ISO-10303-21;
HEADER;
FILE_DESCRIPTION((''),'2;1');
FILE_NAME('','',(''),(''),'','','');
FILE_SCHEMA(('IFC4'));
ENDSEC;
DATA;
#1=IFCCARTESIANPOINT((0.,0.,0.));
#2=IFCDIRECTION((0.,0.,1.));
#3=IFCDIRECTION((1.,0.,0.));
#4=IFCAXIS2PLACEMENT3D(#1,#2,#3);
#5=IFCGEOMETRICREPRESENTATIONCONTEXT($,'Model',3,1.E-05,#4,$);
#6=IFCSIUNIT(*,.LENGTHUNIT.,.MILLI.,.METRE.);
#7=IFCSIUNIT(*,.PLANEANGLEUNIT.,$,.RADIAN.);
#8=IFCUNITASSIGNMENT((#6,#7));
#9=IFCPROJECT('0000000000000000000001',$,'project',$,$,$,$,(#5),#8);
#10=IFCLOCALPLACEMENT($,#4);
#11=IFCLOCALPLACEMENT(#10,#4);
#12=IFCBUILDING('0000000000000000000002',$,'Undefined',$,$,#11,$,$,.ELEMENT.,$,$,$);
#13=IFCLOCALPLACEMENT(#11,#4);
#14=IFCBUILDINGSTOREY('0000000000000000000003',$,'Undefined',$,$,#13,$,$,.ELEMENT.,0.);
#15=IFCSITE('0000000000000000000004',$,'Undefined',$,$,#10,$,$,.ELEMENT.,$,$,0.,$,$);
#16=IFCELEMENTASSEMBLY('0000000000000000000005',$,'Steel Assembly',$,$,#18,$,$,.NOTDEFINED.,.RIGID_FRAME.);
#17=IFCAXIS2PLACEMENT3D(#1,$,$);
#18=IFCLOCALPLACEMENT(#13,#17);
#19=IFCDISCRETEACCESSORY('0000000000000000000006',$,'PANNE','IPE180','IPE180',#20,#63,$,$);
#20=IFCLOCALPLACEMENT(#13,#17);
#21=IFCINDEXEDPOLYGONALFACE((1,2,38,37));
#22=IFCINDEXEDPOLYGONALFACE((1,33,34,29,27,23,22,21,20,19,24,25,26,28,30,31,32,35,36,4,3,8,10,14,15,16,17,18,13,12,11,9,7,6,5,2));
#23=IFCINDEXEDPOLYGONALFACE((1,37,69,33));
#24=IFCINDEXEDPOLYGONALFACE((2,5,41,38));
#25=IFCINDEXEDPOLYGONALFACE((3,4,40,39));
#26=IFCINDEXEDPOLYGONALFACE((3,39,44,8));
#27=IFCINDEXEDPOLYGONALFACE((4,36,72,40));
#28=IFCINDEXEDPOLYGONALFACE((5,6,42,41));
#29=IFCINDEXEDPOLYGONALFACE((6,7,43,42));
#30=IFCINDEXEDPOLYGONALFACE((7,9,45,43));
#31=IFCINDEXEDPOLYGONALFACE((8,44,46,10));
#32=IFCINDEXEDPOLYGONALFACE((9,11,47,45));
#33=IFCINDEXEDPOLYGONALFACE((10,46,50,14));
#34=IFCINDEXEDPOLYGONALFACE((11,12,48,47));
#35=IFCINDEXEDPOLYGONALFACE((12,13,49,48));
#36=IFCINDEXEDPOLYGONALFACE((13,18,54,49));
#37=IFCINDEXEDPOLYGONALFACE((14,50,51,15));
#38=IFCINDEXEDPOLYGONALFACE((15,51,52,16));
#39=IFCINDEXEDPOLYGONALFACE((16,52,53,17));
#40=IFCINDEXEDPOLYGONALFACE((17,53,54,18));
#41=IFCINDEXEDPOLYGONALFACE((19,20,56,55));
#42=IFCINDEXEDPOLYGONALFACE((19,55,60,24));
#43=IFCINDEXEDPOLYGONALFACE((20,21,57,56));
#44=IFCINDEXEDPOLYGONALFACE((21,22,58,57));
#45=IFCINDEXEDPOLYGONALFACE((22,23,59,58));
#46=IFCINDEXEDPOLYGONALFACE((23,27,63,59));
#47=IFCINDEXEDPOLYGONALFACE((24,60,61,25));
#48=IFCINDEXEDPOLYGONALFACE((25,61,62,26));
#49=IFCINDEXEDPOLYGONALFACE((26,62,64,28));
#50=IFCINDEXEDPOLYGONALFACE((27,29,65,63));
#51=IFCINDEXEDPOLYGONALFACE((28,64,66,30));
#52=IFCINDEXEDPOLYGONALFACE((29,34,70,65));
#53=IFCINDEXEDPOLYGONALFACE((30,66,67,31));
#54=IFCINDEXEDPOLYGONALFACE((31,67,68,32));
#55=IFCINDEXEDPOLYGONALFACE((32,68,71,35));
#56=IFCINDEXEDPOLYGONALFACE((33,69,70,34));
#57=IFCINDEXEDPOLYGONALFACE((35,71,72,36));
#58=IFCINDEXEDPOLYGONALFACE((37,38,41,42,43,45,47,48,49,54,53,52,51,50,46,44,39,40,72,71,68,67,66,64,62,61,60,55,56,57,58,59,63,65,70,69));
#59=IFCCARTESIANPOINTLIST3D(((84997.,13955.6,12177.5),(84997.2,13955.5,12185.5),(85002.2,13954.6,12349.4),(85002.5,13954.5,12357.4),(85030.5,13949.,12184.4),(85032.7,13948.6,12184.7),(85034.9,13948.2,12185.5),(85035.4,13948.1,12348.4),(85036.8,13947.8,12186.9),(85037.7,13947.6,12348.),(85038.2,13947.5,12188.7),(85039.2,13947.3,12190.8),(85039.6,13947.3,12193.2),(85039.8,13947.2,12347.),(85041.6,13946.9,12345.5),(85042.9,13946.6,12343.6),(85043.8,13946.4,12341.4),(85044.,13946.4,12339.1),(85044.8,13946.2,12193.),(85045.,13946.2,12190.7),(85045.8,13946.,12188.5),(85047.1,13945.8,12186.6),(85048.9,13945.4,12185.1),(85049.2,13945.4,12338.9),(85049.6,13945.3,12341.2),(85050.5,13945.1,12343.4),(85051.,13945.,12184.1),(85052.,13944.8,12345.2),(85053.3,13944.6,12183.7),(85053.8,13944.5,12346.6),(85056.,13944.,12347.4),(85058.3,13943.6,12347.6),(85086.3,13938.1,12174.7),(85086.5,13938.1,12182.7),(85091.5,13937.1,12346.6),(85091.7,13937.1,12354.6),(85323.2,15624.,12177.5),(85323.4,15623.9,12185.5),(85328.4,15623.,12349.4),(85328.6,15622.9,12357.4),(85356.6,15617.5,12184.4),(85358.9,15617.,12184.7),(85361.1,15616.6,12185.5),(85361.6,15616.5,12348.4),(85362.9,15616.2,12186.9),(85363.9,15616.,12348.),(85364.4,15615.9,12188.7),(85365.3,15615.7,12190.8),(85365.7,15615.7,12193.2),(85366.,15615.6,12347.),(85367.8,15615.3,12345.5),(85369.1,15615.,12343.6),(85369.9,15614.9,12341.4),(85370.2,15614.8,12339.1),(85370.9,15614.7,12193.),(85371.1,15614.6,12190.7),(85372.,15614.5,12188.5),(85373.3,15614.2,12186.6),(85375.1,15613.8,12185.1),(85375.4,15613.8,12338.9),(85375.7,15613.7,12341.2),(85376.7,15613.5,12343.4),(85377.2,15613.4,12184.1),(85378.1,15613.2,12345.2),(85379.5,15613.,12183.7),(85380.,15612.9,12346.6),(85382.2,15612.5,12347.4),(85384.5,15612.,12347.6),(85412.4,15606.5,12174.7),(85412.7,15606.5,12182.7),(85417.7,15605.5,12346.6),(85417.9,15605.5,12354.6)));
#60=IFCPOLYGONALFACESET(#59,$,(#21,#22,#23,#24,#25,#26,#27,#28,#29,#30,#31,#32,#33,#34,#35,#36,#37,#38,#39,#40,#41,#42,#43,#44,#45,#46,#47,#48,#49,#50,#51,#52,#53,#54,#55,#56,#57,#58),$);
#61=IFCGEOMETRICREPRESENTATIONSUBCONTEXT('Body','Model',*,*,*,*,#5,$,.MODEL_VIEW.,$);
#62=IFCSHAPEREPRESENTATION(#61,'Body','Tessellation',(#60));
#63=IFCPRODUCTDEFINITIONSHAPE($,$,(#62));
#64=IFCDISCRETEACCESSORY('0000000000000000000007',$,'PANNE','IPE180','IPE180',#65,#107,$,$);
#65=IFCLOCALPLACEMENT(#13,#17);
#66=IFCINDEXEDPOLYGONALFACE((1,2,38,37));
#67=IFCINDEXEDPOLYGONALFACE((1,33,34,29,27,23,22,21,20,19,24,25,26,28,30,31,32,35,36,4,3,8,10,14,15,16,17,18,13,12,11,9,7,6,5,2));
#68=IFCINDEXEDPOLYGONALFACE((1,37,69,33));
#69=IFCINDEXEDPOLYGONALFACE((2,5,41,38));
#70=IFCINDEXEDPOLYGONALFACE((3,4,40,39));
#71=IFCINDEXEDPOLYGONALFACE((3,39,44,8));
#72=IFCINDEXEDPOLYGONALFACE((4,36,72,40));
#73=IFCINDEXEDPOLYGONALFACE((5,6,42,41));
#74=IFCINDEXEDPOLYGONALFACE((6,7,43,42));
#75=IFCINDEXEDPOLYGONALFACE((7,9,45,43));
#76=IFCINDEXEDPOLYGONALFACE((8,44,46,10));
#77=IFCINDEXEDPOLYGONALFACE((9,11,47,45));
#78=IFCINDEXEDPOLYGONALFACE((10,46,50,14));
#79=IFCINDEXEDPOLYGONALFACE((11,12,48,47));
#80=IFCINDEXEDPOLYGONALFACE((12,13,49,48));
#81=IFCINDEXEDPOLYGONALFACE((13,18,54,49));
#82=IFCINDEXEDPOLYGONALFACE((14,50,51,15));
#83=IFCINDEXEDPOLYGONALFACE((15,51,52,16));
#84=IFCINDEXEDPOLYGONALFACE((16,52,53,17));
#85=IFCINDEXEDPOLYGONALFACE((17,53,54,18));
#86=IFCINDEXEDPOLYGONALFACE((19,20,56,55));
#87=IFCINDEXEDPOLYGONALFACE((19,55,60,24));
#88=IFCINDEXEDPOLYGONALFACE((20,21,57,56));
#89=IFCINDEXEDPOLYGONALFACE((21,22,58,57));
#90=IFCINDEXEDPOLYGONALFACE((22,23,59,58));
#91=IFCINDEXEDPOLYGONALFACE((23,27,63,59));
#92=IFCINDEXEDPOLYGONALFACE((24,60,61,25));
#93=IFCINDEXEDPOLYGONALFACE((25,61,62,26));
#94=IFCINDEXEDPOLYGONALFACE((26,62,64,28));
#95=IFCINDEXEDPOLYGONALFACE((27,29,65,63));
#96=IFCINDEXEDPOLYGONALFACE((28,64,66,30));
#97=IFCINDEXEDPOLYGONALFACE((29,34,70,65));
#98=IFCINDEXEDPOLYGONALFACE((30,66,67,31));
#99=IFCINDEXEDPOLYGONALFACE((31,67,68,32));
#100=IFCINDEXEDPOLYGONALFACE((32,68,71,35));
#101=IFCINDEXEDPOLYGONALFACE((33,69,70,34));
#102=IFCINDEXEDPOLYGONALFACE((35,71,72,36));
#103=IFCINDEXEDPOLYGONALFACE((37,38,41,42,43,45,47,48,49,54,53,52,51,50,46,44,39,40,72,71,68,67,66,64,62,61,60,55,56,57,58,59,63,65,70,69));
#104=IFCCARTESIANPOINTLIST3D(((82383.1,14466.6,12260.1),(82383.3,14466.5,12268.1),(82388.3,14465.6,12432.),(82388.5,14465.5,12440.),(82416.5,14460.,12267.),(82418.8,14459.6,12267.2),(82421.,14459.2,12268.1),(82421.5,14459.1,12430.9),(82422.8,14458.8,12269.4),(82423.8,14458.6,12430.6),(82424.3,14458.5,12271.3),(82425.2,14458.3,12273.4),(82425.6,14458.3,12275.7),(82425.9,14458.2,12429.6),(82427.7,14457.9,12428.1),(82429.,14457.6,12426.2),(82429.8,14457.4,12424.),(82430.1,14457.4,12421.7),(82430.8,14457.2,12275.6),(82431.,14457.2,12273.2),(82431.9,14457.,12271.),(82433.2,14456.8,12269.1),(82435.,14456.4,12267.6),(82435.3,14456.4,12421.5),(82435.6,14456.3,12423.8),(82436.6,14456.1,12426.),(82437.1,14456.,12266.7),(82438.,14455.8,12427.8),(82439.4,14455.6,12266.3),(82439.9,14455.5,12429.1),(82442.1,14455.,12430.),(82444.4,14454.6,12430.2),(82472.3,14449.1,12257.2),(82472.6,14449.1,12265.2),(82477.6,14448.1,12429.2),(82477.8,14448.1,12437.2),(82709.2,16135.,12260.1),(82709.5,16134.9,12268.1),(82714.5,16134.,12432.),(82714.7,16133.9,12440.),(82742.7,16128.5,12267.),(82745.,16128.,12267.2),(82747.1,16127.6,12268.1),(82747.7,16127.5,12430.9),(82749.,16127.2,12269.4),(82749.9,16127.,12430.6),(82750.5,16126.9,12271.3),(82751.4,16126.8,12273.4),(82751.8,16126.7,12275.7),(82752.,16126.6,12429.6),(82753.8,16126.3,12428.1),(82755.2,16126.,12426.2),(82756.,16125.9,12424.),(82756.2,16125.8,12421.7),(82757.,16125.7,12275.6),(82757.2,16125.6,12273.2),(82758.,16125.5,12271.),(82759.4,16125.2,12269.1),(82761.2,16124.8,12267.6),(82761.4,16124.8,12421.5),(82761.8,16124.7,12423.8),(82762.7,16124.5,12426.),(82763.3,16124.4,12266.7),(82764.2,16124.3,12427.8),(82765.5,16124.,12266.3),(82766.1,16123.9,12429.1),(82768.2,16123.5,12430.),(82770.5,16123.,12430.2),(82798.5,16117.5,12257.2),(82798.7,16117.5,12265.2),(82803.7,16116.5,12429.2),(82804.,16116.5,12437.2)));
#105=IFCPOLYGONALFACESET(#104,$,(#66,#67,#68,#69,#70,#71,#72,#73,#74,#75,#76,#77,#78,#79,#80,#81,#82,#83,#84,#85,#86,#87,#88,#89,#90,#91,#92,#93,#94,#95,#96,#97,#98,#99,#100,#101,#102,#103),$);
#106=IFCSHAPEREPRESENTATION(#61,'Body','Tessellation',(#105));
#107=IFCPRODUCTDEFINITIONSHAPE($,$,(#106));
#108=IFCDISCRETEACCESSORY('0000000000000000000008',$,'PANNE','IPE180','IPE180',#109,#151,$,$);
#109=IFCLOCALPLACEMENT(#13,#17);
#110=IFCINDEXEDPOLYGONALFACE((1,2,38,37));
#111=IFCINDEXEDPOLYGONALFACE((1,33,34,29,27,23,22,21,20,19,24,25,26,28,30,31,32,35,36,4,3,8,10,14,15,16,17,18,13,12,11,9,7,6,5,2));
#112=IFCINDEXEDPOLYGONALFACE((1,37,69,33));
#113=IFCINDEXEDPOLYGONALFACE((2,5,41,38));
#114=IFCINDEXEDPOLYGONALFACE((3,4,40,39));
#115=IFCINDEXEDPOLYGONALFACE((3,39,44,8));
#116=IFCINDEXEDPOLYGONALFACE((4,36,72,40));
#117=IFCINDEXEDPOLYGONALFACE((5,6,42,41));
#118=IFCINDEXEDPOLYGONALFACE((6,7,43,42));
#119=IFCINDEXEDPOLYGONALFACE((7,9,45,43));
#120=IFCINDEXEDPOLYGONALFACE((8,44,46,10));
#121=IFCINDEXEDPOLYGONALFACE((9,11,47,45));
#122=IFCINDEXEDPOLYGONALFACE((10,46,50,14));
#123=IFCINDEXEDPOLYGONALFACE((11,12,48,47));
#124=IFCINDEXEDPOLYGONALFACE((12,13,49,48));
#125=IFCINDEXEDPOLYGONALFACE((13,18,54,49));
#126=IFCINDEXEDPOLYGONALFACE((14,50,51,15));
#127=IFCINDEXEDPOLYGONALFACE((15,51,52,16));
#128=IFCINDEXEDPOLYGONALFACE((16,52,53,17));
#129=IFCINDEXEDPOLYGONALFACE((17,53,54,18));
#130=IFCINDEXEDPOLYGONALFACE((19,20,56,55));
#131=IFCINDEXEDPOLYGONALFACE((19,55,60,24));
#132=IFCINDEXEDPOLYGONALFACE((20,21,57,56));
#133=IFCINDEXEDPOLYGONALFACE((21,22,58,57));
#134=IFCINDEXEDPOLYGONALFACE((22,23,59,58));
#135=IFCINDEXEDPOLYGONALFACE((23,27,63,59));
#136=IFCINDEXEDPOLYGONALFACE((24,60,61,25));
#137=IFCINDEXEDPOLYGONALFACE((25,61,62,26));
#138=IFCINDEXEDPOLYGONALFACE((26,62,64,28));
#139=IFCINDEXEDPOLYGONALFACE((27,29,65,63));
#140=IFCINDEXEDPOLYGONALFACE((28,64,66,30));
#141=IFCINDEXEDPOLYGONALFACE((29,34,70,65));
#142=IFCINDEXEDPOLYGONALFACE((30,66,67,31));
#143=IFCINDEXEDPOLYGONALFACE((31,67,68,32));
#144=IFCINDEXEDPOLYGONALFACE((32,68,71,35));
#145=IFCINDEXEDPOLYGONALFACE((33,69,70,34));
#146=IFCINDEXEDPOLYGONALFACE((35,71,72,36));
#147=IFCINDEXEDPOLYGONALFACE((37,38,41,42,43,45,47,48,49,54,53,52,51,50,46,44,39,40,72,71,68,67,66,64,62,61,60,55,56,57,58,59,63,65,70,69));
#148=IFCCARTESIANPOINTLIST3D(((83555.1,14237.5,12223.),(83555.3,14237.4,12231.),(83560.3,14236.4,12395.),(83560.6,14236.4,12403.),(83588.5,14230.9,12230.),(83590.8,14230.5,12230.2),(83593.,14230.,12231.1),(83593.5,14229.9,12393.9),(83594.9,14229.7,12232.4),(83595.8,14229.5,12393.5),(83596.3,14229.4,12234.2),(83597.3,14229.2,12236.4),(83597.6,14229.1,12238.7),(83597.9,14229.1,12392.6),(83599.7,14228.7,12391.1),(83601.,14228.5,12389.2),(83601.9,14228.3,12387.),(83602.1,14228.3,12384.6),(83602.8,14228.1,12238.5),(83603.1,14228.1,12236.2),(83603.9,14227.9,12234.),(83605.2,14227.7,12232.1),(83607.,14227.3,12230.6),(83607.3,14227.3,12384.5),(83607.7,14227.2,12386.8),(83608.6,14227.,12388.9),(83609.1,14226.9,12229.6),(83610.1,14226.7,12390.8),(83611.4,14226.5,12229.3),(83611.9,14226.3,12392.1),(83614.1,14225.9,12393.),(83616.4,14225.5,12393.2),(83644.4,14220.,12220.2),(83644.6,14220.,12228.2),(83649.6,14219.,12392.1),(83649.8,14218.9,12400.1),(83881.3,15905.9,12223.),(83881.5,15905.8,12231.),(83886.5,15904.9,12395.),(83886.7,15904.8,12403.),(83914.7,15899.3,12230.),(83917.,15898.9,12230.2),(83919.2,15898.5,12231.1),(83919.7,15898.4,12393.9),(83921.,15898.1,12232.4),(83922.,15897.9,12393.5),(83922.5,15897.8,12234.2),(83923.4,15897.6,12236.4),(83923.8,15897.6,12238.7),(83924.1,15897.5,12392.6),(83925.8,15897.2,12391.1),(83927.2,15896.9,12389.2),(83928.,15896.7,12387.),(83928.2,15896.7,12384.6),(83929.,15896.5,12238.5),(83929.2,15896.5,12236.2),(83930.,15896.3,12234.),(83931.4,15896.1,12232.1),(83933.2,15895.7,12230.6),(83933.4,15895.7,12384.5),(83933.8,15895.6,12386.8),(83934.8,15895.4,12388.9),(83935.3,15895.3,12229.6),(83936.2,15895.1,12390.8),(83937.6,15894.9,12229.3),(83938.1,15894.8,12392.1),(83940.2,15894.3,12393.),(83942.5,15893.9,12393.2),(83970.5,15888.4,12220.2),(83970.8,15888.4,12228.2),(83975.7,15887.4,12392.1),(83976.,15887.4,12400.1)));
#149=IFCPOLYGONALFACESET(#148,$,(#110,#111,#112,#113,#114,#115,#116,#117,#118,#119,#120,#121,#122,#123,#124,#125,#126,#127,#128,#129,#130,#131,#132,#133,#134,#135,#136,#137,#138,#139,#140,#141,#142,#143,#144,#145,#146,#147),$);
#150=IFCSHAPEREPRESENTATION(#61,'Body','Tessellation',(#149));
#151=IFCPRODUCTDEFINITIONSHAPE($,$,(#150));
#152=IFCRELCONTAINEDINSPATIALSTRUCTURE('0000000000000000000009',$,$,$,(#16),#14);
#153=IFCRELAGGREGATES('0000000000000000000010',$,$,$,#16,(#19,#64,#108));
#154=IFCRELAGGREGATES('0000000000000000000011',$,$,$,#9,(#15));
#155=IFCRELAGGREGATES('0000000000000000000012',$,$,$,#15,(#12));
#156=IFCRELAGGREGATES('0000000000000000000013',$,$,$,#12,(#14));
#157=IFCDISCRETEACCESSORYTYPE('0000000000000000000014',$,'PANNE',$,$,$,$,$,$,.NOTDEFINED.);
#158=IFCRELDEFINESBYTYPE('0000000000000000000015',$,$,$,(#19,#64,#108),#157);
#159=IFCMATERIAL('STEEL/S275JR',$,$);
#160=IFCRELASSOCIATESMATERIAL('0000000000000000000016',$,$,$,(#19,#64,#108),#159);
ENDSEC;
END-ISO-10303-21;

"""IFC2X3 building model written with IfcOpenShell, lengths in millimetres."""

from ifc_helpers import new_model, si_unit, frame, origin_with_axes, origin_2d_with_axis, place, context, subcontext, project, spatial, i_section, extrude, material, type_object, element, aggregate, save


model = new_model("IFC2X3")

# Units and contexts
model_context = context("Model", 3, precision=1e-05, world=origin_with_axes())
body_context = subcontext(model_context, "Body", "Model", "MODEL_VIEW")
ifc_project = project(units=[si_unit("LENGTHUNIT", "METRE", prefix="MILLI"), si_unit("PLANEANGLEUNIT", "RADIAN")], contexts=[model_context])

# Site, building, storey
site_placement = place(None, origin_with_axes())
site = spatial("IfcSite", under=ifc_project, at=site_placement, Name="Undefined", CompositionType="ELEMENT", RefElevation=0.0)
building_placement = place(site_placement, origin_with_axes())
building = spatial("IfcBuilding", under=site, at=building_placement, Name="Undefined", CompositionType="ELEMENT")
storey_placement = place(building_placement, origin_with_axes())
storey = spatial("IfcBuildingStorey", under=building, at=storey_placement, Name="Undefined", CompositionType="ELEMENT", Elevation=0.0)

# Shared definitions
ifc_material_1 = material(Name="STEEL/S275JR")

# Element assembly, discrete accessories
assembly_1_placement = place(storey_placement, origin_with_axes())
assembly_1 = element("IfcElementAssembly", 1, at=assembly_1_placement, inside=storey, Name="Steel Assembly", AssemblyPlace="NOTDEFINED", PredefinedType="RIGID_FRAME")
discrete_accessory_type_1 = type_object("IfcDiscreteAccessoryType", Name="PANNE")
discrete_accessory_1_placement = place(assembly_1_placement, frame((85044.4, 13946.3, 12266.0), z_axis=(0.030408, -0.005945, 0.99952), x_axis=(0.191859, 0.981422, 0.0)))
discrete_accessory_1 = element("IfcDiscreteAccessory", 2, at=discrete_accessory_1_placement, type_object=discrete_accessory_type_1, material=ifc_material_1, Name="PANNE", Description="IPE180", ObjectType="IPE180", context=body_context, shape_type="SweptSolid", body=[
    extrude(i_section(OverallWidth=91.0, OverallDepth=180.0, WebThickness=5.3, FlangeThickness=8.0, FilletRadius=9.0, at=origin_2d_with_axis()), frame((1700.0, 0.0, 0.0), z_axis=(-1.0, 0.0, 0.0), x_axis=(0.0, -1.0, 0.0)), (0.0, 0.0, 1.0), 1700.0),
])
discrete_accessory_2_placement = place(assembly_1_placement, frame((82430.4, 14457.3, 12348.6), z_axis=(0.030408, -0.005945, 0.99952), x_axis=(0.191859, 0.981422, 0.0)))
discrete_accessory_2 = element("IfcDiscreteAccessory", 3, at=discrete_accessory_2_placement, type_object=discrete_accessory_type_1, material=ifc_material_1, Name="PANNE", Description="IPE180", ObjectType="IPE180", context=body_context, shape_type="SweptSolid", body=[
    extrude(i_section(OverallWidth=91.0, OverallDepth=180.0, WebThickness=5.3, FlangeThickness=8.0, FilletRadius=9.0, at=origin_2d_with_axis()), frame((1700.0, 0.0, 0.0), z_axis=(-1.0, 0.0, 0.0), x_axis=(0.0, -1.0, 0.0)), (0.0, 0.0, 1.0), 1700.0),
])
discrete_accessory_3_placement = place(assembly_1_placement, frame((83602.5, 14228.2, 12311.6), z_axis=(0.030408, -0.005945, 0.99952), x_axis=(0.191859, 0.981422, 0.0)))
discrete_accessory_3 = element("IfcDiscreteAccessory", 4, at=discrete_accessory_3_placement, type_object=discrete_accessory_type_1, material=ifc_material_1, Name="PANNE", Description="IPE180", ObjectType="IPE180", context=body_context, shape_type="SweptSolid", body=[
    extrude(i_section(OverallWidth=91.0, OverallDepth=180.0, WebThickness=5.3, FlangeThickness=8.0, FilletRadius=9.0, at=origin_2d_with_axis()), frame((1700.0, 0.0, 0.0), z_axis=(-1.0, 0.0, 0.0), x_axis=(0.0, -1.0, 0.0)), (0.0, 0.0, 1.0), 1700.0),
])
aggregate(assembly_1, [discrete_accessory_1, discrete_accessory_2, discrete_accessory_3])

save(model, "model.ifc")
